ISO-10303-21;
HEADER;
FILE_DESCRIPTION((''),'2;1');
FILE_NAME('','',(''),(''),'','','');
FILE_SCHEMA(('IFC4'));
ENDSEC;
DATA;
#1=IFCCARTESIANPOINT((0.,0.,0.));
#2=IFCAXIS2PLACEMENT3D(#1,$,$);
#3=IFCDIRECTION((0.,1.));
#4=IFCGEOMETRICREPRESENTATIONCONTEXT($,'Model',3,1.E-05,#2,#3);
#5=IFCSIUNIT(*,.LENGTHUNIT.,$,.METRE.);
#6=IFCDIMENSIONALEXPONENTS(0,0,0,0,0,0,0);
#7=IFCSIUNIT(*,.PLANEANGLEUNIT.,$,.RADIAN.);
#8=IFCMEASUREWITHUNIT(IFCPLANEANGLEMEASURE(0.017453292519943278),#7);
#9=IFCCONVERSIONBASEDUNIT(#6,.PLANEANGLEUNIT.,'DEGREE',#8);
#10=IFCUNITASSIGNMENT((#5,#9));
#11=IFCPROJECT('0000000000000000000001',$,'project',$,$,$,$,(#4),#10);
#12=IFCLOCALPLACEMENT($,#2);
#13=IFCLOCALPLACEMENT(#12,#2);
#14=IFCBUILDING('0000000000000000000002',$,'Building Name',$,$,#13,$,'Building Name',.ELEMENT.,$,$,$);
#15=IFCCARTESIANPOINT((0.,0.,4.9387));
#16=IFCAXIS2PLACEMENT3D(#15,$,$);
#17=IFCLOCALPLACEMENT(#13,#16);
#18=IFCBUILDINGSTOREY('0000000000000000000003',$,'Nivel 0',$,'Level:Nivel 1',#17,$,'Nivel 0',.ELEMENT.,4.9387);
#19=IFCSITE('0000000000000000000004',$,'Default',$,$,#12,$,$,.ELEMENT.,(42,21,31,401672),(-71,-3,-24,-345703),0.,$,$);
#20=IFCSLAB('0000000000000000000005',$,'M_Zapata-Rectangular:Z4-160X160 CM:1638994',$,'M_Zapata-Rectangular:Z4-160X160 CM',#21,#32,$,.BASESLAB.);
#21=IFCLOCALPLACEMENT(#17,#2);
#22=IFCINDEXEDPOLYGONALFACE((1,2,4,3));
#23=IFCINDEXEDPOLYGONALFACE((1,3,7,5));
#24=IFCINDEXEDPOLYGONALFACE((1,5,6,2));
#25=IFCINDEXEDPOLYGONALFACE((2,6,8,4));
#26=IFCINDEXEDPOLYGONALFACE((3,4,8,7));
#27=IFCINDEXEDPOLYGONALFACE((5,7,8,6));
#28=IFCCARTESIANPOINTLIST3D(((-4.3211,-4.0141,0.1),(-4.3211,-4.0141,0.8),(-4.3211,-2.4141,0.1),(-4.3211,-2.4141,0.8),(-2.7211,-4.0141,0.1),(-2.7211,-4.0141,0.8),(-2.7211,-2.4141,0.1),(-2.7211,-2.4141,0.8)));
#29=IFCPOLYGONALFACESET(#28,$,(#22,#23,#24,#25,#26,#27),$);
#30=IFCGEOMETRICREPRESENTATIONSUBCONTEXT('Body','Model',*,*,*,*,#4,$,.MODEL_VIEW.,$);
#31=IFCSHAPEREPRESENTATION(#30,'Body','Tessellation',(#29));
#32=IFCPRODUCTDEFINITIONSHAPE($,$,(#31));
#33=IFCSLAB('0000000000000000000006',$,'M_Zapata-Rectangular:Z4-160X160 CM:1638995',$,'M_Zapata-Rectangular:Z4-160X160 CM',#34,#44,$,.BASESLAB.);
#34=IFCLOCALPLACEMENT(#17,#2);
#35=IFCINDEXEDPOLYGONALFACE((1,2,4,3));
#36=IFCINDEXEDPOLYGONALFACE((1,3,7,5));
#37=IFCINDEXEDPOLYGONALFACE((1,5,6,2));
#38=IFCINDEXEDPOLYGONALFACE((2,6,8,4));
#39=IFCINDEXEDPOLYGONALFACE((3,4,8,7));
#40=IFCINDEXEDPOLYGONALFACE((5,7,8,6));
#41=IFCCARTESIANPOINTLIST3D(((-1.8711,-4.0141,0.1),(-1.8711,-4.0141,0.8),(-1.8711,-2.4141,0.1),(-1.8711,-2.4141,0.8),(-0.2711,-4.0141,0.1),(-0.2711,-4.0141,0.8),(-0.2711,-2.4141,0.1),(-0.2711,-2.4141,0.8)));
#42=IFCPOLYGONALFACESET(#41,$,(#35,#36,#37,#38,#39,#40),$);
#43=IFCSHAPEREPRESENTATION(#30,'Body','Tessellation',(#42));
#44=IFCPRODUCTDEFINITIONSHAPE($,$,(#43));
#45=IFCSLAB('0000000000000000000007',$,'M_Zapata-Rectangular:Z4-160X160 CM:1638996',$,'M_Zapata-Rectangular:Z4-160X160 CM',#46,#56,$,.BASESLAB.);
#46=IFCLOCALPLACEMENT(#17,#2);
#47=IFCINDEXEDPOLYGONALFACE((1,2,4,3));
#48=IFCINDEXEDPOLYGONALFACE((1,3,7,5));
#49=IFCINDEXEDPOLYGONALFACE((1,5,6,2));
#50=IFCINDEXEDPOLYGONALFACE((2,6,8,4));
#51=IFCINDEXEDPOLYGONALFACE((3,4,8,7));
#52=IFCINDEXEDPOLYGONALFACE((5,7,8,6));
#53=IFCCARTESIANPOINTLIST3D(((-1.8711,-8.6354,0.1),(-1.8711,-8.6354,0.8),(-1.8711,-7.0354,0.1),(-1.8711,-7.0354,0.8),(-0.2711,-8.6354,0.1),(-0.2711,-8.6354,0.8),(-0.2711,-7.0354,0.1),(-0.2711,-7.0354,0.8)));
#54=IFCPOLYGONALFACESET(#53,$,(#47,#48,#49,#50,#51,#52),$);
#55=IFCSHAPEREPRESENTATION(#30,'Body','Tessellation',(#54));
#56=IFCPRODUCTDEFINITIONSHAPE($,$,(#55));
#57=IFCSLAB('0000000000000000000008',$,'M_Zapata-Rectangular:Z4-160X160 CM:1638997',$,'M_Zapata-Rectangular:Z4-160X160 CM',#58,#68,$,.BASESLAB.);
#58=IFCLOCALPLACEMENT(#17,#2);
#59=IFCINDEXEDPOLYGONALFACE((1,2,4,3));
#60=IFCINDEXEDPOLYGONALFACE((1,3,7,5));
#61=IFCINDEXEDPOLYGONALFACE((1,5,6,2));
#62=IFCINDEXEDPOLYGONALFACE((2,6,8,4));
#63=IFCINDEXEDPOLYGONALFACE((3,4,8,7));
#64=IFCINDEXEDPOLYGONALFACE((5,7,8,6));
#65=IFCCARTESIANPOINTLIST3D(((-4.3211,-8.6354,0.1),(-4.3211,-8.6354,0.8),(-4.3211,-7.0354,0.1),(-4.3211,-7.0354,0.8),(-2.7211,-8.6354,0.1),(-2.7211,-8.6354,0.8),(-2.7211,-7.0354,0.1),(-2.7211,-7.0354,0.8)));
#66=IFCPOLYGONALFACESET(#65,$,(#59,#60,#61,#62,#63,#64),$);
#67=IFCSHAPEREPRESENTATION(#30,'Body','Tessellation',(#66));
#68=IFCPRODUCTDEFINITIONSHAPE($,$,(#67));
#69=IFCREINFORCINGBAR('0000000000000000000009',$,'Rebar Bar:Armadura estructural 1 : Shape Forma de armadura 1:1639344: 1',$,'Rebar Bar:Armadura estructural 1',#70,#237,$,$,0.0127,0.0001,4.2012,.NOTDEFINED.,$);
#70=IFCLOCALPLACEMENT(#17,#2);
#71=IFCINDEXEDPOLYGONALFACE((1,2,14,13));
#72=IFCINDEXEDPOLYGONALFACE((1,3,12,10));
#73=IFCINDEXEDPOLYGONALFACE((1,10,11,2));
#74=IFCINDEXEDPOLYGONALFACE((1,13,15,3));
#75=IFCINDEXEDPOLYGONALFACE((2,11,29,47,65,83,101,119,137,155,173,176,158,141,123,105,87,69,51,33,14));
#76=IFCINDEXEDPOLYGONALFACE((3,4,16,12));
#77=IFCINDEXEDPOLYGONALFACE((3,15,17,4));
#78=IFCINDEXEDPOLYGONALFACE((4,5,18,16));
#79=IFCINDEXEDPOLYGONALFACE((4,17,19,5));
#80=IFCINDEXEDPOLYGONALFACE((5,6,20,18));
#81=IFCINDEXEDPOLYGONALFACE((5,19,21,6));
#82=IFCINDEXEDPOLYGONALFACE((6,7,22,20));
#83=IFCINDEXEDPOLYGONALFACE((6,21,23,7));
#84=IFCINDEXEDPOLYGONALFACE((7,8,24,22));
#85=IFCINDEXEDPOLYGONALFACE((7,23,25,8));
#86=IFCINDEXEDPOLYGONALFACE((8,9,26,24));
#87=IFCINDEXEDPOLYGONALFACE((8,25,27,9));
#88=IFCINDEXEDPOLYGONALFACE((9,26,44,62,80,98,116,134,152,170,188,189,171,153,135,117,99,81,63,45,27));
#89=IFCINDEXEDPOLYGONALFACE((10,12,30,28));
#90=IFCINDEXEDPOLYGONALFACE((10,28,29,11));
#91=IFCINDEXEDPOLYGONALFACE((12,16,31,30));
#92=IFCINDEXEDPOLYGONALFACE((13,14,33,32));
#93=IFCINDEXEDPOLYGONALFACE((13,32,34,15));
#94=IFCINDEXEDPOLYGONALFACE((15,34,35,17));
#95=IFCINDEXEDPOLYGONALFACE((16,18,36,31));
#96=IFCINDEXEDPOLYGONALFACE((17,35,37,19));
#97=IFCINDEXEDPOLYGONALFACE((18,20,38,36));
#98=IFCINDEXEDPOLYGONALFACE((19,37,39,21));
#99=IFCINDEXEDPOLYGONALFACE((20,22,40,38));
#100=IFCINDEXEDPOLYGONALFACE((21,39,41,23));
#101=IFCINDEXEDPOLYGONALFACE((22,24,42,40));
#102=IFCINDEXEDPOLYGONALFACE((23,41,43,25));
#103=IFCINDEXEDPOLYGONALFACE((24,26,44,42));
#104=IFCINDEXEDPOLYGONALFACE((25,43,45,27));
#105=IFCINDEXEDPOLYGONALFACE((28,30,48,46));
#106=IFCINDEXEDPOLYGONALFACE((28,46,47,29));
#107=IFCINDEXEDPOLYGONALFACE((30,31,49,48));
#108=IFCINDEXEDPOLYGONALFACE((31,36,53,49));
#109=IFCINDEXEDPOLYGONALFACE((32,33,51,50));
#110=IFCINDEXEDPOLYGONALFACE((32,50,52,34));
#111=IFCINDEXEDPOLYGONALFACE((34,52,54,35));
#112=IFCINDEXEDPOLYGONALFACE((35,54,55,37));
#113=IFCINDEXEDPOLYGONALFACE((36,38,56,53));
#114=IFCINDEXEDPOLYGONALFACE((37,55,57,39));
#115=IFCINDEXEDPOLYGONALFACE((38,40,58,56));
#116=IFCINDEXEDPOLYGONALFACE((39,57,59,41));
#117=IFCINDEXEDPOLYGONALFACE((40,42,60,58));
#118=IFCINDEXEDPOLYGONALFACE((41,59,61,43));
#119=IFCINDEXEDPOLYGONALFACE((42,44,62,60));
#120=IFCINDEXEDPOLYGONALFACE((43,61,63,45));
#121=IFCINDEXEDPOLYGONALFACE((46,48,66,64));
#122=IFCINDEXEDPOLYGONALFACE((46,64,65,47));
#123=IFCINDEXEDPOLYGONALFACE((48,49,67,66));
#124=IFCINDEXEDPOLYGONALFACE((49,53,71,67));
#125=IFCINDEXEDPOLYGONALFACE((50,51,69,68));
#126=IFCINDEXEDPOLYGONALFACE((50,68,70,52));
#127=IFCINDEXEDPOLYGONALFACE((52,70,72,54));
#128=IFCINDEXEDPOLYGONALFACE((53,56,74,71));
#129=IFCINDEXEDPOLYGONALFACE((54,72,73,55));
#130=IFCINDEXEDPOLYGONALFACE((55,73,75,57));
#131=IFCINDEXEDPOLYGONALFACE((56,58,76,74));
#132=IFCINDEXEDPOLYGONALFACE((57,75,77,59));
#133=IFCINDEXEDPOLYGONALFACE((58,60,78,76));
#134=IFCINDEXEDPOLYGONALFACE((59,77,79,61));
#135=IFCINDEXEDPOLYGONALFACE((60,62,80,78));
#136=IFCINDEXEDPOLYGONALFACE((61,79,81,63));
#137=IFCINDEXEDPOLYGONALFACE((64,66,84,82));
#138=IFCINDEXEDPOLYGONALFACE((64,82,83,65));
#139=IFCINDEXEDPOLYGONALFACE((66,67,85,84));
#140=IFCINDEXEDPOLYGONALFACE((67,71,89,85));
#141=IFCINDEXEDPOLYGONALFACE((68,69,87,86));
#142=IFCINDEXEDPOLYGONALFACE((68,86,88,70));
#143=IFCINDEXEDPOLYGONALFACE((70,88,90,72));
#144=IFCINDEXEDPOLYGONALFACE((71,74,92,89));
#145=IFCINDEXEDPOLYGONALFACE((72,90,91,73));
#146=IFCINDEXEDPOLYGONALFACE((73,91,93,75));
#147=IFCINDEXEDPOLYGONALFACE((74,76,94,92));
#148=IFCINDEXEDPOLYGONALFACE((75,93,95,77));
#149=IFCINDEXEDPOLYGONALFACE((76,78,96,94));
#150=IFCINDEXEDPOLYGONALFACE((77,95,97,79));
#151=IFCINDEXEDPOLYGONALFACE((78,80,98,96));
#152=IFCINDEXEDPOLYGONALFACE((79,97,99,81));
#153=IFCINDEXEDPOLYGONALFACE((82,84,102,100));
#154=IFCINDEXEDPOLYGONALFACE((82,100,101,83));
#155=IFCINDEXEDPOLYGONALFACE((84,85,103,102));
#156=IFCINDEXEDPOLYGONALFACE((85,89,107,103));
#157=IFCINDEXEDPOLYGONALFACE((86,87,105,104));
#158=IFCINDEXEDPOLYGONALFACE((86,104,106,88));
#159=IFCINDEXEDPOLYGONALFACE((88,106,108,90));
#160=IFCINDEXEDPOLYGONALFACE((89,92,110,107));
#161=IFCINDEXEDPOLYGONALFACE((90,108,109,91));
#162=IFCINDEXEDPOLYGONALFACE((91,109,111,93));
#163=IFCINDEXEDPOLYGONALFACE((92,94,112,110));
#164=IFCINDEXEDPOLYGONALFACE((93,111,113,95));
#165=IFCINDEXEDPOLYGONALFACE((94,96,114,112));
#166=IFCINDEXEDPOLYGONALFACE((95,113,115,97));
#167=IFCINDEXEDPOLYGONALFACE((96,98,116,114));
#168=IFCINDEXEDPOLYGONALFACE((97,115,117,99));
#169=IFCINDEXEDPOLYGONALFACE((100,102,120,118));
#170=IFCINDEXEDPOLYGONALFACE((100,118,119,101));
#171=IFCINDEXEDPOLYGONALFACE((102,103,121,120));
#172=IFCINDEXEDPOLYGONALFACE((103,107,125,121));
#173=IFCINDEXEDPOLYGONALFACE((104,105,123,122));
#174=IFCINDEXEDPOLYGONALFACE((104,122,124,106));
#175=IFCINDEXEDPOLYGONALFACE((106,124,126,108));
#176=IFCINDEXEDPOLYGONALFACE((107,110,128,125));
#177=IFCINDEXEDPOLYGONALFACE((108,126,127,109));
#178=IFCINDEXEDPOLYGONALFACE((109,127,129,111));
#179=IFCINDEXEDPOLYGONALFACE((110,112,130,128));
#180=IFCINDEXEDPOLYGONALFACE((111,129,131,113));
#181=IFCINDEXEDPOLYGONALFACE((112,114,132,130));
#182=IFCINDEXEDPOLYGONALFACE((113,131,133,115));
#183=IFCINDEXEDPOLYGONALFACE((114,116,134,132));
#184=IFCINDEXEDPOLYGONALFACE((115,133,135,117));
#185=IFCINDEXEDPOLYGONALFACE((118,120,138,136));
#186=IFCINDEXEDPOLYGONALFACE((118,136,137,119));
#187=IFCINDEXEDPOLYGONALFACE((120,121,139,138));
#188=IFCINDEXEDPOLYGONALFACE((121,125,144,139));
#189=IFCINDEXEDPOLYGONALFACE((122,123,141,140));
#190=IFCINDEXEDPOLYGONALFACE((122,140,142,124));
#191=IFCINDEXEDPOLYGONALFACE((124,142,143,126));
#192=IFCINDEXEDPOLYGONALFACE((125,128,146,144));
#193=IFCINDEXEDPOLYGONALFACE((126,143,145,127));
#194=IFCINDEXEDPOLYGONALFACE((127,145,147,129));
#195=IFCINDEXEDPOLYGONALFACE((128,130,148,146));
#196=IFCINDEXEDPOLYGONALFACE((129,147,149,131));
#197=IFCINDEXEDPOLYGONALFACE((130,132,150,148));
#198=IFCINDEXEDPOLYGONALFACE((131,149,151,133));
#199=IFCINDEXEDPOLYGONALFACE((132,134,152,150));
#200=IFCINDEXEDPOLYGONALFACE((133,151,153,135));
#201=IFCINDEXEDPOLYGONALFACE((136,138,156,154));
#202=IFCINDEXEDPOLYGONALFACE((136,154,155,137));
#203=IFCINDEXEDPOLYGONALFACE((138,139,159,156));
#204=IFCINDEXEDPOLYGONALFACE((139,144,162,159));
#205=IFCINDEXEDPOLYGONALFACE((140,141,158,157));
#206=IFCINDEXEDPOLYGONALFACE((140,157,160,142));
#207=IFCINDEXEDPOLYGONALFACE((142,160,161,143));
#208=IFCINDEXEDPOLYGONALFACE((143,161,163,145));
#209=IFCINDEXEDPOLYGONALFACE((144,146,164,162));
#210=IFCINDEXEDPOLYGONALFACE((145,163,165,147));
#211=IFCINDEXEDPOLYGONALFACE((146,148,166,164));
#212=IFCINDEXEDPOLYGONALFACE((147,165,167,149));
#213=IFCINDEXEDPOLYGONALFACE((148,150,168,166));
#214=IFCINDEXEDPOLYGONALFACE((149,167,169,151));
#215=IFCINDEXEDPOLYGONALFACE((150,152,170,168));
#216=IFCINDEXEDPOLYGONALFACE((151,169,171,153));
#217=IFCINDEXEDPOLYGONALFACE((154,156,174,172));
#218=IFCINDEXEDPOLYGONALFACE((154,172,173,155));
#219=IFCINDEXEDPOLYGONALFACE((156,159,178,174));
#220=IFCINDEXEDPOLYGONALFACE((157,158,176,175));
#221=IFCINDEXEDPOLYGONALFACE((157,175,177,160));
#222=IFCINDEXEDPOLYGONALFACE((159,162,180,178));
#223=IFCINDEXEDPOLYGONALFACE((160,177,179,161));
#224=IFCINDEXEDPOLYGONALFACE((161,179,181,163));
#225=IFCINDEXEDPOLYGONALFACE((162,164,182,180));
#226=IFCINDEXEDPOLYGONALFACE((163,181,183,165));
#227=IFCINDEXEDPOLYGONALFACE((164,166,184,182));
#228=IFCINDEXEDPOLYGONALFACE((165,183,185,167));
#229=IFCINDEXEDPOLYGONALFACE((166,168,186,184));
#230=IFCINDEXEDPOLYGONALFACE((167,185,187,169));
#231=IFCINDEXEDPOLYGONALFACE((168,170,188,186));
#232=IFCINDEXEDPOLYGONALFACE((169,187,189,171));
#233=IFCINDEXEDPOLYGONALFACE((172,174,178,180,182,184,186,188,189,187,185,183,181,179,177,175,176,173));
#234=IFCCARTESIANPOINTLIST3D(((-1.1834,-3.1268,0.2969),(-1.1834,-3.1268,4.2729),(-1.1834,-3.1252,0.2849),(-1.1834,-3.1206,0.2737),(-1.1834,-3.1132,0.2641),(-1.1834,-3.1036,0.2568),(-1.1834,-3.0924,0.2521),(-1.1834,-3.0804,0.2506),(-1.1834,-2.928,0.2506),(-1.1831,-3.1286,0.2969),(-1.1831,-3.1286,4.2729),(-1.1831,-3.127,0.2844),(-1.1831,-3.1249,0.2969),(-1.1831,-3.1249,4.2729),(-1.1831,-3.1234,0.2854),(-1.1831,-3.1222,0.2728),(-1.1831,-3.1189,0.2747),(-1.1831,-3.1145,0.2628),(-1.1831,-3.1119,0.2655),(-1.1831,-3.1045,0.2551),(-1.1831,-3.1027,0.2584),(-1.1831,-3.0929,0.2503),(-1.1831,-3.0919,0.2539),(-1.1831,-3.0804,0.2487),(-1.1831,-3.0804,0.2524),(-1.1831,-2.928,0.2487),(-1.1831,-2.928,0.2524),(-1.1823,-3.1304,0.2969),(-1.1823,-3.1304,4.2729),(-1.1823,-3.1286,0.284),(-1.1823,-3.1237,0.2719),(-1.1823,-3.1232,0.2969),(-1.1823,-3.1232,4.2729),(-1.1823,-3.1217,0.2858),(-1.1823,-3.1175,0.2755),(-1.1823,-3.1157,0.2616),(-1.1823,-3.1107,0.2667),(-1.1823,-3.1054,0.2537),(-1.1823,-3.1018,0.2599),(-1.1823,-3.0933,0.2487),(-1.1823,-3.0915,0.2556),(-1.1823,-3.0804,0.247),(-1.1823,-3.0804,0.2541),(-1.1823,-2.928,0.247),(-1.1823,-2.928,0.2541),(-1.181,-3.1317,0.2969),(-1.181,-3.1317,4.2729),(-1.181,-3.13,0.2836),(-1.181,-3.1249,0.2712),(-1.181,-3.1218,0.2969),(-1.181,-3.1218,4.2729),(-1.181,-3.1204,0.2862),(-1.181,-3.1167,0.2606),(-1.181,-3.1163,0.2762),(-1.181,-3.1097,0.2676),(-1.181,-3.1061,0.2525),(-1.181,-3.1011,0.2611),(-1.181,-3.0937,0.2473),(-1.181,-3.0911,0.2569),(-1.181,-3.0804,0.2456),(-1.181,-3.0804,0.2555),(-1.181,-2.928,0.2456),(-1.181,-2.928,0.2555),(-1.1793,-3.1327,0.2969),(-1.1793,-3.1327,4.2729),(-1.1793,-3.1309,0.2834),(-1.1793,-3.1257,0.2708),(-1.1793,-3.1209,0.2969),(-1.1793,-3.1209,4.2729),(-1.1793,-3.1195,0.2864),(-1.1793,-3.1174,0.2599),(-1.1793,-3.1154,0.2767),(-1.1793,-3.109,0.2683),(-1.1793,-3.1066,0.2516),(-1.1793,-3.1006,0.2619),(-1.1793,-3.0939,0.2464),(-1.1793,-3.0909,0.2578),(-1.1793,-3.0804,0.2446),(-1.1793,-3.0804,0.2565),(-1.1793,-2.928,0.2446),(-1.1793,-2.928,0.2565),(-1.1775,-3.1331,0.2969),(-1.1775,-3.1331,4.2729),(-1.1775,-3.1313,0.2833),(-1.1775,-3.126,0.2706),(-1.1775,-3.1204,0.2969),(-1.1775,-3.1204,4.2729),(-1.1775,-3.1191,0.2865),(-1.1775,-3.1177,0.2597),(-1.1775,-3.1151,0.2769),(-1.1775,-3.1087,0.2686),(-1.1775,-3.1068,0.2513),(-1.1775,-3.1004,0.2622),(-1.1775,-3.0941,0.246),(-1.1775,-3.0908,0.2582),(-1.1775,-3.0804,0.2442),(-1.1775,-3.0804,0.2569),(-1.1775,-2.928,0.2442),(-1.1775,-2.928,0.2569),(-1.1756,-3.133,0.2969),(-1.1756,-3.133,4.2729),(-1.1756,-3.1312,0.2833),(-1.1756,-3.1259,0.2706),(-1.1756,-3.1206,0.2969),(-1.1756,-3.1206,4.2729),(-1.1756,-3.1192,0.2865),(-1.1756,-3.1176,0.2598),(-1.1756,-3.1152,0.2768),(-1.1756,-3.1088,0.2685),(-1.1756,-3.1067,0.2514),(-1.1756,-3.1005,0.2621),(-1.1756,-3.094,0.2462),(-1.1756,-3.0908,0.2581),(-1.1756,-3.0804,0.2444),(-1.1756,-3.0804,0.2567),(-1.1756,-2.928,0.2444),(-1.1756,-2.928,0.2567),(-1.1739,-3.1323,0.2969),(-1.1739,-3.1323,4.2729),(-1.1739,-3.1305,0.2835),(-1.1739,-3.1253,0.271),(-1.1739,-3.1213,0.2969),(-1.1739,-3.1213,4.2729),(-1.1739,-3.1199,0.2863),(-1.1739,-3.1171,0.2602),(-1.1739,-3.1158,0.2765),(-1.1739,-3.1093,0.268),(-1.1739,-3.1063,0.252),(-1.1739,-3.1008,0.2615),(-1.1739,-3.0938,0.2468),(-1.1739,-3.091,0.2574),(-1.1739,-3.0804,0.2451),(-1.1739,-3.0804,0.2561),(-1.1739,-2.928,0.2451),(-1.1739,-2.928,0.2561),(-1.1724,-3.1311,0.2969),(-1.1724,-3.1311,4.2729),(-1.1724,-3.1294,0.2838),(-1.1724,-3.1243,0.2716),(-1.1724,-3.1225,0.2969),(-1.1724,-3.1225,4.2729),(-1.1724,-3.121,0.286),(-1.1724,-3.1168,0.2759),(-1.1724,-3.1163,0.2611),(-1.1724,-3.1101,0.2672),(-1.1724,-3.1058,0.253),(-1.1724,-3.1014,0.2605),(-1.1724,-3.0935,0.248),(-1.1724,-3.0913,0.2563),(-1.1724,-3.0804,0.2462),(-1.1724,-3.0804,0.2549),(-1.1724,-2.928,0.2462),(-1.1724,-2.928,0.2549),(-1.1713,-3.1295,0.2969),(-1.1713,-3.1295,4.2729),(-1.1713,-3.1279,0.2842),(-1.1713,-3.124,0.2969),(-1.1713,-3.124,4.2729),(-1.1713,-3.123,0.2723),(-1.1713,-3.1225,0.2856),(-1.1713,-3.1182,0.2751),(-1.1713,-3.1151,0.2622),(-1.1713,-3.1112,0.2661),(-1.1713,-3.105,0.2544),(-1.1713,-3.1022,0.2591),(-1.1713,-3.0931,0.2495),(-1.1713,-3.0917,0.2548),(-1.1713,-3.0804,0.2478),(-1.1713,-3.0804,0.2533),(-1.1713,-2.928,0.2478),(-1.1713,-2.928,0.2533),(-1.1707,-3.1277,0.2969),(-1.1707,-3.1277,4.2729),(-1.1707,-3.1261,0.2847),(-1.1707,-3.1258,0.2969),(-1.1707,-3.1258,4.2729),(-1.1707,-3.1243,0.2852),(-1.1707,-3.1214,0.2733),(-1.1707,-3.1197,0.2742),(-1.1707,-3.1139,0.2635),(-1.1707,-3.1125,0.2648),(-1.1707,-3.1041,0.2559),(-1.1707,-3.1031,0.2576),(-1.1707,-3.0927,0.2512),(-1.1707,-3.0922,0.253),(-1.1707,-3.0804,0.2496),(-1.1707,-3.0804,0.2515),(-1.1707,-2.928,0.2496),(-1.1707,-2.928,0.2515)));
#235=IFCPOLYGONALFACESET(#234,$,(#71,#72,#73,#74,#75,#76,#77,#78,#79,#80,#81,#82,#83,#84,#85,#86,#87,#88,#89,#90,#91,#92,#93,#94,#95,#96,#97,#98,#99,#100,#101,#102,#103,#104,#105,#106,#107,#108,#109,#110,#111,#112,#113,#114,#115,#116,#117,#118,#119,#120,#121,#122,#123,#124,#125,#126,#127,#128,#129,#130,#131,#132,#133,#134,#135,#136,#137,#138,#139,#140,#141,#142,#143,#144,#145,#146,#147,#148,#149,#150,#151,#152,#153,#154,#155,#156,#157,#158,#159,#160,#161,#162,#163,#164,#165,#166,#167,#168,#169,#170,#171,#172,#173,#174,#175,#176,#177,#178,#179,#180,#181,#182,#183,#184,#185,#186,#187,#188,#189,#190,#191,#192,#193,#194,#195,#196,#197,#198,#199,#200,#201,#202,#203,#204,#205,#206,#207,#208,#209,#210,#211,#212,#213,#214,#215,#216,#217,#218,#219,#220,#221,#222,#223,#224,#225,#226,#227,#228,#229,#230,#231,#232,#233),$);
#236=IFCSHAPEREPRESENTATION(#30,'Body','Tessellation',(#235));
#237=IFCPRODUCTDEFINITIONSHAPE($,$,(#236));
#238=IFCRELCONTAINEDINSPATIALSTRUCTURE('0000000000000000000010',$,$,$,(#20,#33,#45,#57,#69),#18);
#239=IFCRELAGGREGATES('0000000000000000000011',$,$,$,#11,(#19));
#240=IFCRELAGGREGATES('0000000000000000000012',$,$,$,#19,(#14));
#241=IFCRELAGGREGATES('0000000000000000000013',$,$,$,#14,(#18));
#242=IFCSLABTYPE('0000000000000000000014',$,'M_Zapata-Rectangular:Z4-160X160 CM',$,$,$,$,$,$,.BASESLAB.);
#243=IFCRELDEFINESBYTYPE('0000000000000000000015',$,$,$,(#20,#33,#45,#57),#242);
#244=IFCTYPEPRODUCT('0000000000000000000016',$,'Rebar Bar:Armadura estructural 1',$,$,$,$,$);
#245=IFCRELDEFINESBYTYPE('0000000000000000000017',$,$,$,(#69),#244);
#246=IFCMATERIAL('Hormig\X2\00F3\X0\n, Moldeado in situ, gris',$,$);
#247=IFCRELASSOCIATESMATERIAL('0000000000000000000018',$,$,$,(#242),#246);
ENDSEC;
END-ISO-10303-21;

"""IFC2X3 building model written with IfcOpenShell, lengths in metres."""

from ifc_helpers import new_model, entity, si_unit, converted_unit, direction, frame, frame_2d, origin, origin_2d_with_axis, place, context, subcontext, project, spatial, rectangle, extrude, material, type_object, element, save


model = new_model("IFC2X3")

# Units and contexts
model_context = context("Model", 3, precision=1e-05, world=origin(), true_north=direction((0.0, 1.0)))
body_context = subcontext(model_context, "Body", "Model", "MODEL_VIEW")
ifc_project = project(units=[si_unit("LENGTHUNIT", "METRE"), converted_unit("PLANEANGLEUNIT", "DEGREE", entity("IfcPlaneAngleMeasure", 0.017453292519943278), si_unit("PLANEANGLEUNIT", "RADIAN"), dimensions=[0, 0, 0, 0, 0, 0, 0])], contexts=[model_context])

# Site, building, storey
site_placement = place(None, origin())
site = spatial("IfcSite", under=ifc_project, at=site_placement, Name="Default", CompositionType="ELEMENT", RefLatitude=(42, 21, 31, 401672), RefLongitude=(-71, -3, -24, -345703), RefElevation=0.0)
building_placement = place(site_placement, origin())
building = spatial("IfcBuilding", under=site, at=building_placement, Name="Building Name", LongName="Building Name", CompositionType="ELEMENT")
storey_placement = place(building_placement, frame((0.0, 0.0, 4.9387)))
storey = spatial("IfcBuildingStorey", under=building, at=storey_placement, Name="Nivel 0", ObjectType="Level:Nivel 1", LongName="Nivel 0", CompositionType="ELEMENT", Elevation=4.9387)

# Slabs
ifc_material = material(Name="Hormigón, Moldeado in situ, gris")
slab_type = type_object("IfcSlabType", Name="M_Zapata-Rectangular:Z4-160X160 CM", PredefinedType="BASESLAB", material=ifc_material)
slab_1_placement = place(storey_placement, origin())
element("IfcSlab", 1, at=slab_1_placement, inside=storey, type_object=slab_type, Name="M_Zapata-Rectangular:Z4-160X160 CM:1638994", ObjectType="M_Zapata-Rectangular:Z4-160X160 CM", PredefinedType="BASESLAB", context=body_context, shape_type="SweptSolid", body=[
    extrude(rectangle(XDim=1.6, YDim=1.6, at=origin_2d_with_axis()), frame((-3.5211, -3.2141, 0.1), z_axis=(0.0, 0.0, 1.0), x_axis=(-1.0, 0.0, 0.0)), (0.0, 0.0, 1.0), 0.7),
])
slab_2_placement = place(storey_placement, origin())
element("IfcSlab", 2, at=slab_2_placement, inside=storey, type_object=slab_type, Name="M_Zapata-Rectangular:Z4-160X160 CM:1638995", ObjectType="M_Zapata-Rectangular:Z4-160X160 CM", PredefinedType="BASESLAB", context=body_context, shape_type="SweptSolid", body=[
    extrude(rectangle(XDim=1.6, YDim=1.6, at=frame_2d((0.0, 0.0), x_axis=(1.0, 0.0))), frame((-1.0711, -3.2141, 0.1), z_axis=(0.0, 0.0, 1.0), x_axis=(-1.0, 0.0, 0.0)), (0.0, 0.0, 1.0), 0.7),
])
slab_3_placement = place(storey_placement, origin())
element("IfcSlab", 3, at=slab_3_placement, inside=storey, type_object=slab_type, Name="M_Zapata-Rectangular:Z4-160X160 CM:1638996", ObjectType="M_Zapata-Rectangular:Z4-160X160 CM", PredefinedType="BASESLAB", context=body_context, shape_type="SweptSolid", body=[
    extrude(rectangle(XDim=1.6, YDim=1.6, at=frame_2d((0.0, 0.0), x_axis=(1.0, 0.0))), frame((-1.0711, -7.8354, 0.1), z_axis=(0.0, 0.0, 1.0), x_axis=(-1.0, 0.0, 0.0)), (0.0, 0.0, 1.0), 0.7),
])
slab_4_placement = place(storey_placement, origin())
element("IfcSlab", 4, at=slab_4_placement, inside=storey, type_object=slab_type, Name="M_Zapata-Rectangular:Z4-160X160 CM:1638997", ObjectType="M_Zapata-Rectangular:Z4-160X160 CM", PredefinedType="BASESLAB", context=body_context, shape_type="SweptSolid", body=[
    extrude(rectangle(XDim=1.6, YDim=1.6, at=origin_2d_with_axis()), frame((-3.5211, -7.8354, 0.1), z_axis=(0.0, 0.0, 1.0), x_axis=(-1.0, 0.0, 0.0)), (0.0, 0.0, 1.0), 0.7),
])

# Reinforcing bar
type_product = type_object("IfcTypeProduct", Name="Rebar Bar:Armadura estructural 1")
reinforcing_bar_1_placement = place(storey_placement, origin())
element("IfcReinforcingBar", 5, at=reinforcing_bar_1_placement, inside=storey, type_object=type_product, Name="Rebar Bar:Armadura estructural 1 : Shape Forma de armadura 1:1639344: 1", ObjectType="Rebar Bar:Armadura estructural 1", BarLength=4.2012, BarRole="NOTDEFINED", CrossSectionArea=0.0001, NominalDiameter=0.0127, context=body_context, shape_type="AdvancedSweptSolid", body=[
    entity("IfcSweptDiskSolid", entity("IfcCompositeCurve", [entity("IfcCompositeCurveSegment", "CONTINUOUS", True, entity("IfcPolyline", [entity("IfcCartesianPoint", [-1.177, -2.928, 0.2506]), entity("IfcCartesianPoint", [-1.177, -3.0804, 0.2506])])), entity("IfcCompositeCurveSegment", "CONTINUOUS", True, entity("IfcTrimmedCurve", entity("IfcCircle", entity("IfcAxis2Placement3D", entity("IfcCartesianPoint", [-1.177, -3.0804, 0.2969]), entity("IfcDirection", [-1.0, 0.0, 0.0]), entity("IfcDirection", [0.0, -1.0, 0.0])), 0.0464), [entity("IfcParameterValue", 270.0)], [entity("IfcParameterValue", 360.0)], True, "PARAMETER")), entity("IfcCompositeCurveSegment", "CONTINUOUS", True, entity("IfcPolyline", [entity("IfcCartesianPoint", [-1.177, -3.1268, 0.2969]), entity("IfcCartesianPoint", [-1.177, -3.1268, 4.2729])]))], False), 0.0063, None, 0.0, 92.0),
])

save(model, "model.ifc")
